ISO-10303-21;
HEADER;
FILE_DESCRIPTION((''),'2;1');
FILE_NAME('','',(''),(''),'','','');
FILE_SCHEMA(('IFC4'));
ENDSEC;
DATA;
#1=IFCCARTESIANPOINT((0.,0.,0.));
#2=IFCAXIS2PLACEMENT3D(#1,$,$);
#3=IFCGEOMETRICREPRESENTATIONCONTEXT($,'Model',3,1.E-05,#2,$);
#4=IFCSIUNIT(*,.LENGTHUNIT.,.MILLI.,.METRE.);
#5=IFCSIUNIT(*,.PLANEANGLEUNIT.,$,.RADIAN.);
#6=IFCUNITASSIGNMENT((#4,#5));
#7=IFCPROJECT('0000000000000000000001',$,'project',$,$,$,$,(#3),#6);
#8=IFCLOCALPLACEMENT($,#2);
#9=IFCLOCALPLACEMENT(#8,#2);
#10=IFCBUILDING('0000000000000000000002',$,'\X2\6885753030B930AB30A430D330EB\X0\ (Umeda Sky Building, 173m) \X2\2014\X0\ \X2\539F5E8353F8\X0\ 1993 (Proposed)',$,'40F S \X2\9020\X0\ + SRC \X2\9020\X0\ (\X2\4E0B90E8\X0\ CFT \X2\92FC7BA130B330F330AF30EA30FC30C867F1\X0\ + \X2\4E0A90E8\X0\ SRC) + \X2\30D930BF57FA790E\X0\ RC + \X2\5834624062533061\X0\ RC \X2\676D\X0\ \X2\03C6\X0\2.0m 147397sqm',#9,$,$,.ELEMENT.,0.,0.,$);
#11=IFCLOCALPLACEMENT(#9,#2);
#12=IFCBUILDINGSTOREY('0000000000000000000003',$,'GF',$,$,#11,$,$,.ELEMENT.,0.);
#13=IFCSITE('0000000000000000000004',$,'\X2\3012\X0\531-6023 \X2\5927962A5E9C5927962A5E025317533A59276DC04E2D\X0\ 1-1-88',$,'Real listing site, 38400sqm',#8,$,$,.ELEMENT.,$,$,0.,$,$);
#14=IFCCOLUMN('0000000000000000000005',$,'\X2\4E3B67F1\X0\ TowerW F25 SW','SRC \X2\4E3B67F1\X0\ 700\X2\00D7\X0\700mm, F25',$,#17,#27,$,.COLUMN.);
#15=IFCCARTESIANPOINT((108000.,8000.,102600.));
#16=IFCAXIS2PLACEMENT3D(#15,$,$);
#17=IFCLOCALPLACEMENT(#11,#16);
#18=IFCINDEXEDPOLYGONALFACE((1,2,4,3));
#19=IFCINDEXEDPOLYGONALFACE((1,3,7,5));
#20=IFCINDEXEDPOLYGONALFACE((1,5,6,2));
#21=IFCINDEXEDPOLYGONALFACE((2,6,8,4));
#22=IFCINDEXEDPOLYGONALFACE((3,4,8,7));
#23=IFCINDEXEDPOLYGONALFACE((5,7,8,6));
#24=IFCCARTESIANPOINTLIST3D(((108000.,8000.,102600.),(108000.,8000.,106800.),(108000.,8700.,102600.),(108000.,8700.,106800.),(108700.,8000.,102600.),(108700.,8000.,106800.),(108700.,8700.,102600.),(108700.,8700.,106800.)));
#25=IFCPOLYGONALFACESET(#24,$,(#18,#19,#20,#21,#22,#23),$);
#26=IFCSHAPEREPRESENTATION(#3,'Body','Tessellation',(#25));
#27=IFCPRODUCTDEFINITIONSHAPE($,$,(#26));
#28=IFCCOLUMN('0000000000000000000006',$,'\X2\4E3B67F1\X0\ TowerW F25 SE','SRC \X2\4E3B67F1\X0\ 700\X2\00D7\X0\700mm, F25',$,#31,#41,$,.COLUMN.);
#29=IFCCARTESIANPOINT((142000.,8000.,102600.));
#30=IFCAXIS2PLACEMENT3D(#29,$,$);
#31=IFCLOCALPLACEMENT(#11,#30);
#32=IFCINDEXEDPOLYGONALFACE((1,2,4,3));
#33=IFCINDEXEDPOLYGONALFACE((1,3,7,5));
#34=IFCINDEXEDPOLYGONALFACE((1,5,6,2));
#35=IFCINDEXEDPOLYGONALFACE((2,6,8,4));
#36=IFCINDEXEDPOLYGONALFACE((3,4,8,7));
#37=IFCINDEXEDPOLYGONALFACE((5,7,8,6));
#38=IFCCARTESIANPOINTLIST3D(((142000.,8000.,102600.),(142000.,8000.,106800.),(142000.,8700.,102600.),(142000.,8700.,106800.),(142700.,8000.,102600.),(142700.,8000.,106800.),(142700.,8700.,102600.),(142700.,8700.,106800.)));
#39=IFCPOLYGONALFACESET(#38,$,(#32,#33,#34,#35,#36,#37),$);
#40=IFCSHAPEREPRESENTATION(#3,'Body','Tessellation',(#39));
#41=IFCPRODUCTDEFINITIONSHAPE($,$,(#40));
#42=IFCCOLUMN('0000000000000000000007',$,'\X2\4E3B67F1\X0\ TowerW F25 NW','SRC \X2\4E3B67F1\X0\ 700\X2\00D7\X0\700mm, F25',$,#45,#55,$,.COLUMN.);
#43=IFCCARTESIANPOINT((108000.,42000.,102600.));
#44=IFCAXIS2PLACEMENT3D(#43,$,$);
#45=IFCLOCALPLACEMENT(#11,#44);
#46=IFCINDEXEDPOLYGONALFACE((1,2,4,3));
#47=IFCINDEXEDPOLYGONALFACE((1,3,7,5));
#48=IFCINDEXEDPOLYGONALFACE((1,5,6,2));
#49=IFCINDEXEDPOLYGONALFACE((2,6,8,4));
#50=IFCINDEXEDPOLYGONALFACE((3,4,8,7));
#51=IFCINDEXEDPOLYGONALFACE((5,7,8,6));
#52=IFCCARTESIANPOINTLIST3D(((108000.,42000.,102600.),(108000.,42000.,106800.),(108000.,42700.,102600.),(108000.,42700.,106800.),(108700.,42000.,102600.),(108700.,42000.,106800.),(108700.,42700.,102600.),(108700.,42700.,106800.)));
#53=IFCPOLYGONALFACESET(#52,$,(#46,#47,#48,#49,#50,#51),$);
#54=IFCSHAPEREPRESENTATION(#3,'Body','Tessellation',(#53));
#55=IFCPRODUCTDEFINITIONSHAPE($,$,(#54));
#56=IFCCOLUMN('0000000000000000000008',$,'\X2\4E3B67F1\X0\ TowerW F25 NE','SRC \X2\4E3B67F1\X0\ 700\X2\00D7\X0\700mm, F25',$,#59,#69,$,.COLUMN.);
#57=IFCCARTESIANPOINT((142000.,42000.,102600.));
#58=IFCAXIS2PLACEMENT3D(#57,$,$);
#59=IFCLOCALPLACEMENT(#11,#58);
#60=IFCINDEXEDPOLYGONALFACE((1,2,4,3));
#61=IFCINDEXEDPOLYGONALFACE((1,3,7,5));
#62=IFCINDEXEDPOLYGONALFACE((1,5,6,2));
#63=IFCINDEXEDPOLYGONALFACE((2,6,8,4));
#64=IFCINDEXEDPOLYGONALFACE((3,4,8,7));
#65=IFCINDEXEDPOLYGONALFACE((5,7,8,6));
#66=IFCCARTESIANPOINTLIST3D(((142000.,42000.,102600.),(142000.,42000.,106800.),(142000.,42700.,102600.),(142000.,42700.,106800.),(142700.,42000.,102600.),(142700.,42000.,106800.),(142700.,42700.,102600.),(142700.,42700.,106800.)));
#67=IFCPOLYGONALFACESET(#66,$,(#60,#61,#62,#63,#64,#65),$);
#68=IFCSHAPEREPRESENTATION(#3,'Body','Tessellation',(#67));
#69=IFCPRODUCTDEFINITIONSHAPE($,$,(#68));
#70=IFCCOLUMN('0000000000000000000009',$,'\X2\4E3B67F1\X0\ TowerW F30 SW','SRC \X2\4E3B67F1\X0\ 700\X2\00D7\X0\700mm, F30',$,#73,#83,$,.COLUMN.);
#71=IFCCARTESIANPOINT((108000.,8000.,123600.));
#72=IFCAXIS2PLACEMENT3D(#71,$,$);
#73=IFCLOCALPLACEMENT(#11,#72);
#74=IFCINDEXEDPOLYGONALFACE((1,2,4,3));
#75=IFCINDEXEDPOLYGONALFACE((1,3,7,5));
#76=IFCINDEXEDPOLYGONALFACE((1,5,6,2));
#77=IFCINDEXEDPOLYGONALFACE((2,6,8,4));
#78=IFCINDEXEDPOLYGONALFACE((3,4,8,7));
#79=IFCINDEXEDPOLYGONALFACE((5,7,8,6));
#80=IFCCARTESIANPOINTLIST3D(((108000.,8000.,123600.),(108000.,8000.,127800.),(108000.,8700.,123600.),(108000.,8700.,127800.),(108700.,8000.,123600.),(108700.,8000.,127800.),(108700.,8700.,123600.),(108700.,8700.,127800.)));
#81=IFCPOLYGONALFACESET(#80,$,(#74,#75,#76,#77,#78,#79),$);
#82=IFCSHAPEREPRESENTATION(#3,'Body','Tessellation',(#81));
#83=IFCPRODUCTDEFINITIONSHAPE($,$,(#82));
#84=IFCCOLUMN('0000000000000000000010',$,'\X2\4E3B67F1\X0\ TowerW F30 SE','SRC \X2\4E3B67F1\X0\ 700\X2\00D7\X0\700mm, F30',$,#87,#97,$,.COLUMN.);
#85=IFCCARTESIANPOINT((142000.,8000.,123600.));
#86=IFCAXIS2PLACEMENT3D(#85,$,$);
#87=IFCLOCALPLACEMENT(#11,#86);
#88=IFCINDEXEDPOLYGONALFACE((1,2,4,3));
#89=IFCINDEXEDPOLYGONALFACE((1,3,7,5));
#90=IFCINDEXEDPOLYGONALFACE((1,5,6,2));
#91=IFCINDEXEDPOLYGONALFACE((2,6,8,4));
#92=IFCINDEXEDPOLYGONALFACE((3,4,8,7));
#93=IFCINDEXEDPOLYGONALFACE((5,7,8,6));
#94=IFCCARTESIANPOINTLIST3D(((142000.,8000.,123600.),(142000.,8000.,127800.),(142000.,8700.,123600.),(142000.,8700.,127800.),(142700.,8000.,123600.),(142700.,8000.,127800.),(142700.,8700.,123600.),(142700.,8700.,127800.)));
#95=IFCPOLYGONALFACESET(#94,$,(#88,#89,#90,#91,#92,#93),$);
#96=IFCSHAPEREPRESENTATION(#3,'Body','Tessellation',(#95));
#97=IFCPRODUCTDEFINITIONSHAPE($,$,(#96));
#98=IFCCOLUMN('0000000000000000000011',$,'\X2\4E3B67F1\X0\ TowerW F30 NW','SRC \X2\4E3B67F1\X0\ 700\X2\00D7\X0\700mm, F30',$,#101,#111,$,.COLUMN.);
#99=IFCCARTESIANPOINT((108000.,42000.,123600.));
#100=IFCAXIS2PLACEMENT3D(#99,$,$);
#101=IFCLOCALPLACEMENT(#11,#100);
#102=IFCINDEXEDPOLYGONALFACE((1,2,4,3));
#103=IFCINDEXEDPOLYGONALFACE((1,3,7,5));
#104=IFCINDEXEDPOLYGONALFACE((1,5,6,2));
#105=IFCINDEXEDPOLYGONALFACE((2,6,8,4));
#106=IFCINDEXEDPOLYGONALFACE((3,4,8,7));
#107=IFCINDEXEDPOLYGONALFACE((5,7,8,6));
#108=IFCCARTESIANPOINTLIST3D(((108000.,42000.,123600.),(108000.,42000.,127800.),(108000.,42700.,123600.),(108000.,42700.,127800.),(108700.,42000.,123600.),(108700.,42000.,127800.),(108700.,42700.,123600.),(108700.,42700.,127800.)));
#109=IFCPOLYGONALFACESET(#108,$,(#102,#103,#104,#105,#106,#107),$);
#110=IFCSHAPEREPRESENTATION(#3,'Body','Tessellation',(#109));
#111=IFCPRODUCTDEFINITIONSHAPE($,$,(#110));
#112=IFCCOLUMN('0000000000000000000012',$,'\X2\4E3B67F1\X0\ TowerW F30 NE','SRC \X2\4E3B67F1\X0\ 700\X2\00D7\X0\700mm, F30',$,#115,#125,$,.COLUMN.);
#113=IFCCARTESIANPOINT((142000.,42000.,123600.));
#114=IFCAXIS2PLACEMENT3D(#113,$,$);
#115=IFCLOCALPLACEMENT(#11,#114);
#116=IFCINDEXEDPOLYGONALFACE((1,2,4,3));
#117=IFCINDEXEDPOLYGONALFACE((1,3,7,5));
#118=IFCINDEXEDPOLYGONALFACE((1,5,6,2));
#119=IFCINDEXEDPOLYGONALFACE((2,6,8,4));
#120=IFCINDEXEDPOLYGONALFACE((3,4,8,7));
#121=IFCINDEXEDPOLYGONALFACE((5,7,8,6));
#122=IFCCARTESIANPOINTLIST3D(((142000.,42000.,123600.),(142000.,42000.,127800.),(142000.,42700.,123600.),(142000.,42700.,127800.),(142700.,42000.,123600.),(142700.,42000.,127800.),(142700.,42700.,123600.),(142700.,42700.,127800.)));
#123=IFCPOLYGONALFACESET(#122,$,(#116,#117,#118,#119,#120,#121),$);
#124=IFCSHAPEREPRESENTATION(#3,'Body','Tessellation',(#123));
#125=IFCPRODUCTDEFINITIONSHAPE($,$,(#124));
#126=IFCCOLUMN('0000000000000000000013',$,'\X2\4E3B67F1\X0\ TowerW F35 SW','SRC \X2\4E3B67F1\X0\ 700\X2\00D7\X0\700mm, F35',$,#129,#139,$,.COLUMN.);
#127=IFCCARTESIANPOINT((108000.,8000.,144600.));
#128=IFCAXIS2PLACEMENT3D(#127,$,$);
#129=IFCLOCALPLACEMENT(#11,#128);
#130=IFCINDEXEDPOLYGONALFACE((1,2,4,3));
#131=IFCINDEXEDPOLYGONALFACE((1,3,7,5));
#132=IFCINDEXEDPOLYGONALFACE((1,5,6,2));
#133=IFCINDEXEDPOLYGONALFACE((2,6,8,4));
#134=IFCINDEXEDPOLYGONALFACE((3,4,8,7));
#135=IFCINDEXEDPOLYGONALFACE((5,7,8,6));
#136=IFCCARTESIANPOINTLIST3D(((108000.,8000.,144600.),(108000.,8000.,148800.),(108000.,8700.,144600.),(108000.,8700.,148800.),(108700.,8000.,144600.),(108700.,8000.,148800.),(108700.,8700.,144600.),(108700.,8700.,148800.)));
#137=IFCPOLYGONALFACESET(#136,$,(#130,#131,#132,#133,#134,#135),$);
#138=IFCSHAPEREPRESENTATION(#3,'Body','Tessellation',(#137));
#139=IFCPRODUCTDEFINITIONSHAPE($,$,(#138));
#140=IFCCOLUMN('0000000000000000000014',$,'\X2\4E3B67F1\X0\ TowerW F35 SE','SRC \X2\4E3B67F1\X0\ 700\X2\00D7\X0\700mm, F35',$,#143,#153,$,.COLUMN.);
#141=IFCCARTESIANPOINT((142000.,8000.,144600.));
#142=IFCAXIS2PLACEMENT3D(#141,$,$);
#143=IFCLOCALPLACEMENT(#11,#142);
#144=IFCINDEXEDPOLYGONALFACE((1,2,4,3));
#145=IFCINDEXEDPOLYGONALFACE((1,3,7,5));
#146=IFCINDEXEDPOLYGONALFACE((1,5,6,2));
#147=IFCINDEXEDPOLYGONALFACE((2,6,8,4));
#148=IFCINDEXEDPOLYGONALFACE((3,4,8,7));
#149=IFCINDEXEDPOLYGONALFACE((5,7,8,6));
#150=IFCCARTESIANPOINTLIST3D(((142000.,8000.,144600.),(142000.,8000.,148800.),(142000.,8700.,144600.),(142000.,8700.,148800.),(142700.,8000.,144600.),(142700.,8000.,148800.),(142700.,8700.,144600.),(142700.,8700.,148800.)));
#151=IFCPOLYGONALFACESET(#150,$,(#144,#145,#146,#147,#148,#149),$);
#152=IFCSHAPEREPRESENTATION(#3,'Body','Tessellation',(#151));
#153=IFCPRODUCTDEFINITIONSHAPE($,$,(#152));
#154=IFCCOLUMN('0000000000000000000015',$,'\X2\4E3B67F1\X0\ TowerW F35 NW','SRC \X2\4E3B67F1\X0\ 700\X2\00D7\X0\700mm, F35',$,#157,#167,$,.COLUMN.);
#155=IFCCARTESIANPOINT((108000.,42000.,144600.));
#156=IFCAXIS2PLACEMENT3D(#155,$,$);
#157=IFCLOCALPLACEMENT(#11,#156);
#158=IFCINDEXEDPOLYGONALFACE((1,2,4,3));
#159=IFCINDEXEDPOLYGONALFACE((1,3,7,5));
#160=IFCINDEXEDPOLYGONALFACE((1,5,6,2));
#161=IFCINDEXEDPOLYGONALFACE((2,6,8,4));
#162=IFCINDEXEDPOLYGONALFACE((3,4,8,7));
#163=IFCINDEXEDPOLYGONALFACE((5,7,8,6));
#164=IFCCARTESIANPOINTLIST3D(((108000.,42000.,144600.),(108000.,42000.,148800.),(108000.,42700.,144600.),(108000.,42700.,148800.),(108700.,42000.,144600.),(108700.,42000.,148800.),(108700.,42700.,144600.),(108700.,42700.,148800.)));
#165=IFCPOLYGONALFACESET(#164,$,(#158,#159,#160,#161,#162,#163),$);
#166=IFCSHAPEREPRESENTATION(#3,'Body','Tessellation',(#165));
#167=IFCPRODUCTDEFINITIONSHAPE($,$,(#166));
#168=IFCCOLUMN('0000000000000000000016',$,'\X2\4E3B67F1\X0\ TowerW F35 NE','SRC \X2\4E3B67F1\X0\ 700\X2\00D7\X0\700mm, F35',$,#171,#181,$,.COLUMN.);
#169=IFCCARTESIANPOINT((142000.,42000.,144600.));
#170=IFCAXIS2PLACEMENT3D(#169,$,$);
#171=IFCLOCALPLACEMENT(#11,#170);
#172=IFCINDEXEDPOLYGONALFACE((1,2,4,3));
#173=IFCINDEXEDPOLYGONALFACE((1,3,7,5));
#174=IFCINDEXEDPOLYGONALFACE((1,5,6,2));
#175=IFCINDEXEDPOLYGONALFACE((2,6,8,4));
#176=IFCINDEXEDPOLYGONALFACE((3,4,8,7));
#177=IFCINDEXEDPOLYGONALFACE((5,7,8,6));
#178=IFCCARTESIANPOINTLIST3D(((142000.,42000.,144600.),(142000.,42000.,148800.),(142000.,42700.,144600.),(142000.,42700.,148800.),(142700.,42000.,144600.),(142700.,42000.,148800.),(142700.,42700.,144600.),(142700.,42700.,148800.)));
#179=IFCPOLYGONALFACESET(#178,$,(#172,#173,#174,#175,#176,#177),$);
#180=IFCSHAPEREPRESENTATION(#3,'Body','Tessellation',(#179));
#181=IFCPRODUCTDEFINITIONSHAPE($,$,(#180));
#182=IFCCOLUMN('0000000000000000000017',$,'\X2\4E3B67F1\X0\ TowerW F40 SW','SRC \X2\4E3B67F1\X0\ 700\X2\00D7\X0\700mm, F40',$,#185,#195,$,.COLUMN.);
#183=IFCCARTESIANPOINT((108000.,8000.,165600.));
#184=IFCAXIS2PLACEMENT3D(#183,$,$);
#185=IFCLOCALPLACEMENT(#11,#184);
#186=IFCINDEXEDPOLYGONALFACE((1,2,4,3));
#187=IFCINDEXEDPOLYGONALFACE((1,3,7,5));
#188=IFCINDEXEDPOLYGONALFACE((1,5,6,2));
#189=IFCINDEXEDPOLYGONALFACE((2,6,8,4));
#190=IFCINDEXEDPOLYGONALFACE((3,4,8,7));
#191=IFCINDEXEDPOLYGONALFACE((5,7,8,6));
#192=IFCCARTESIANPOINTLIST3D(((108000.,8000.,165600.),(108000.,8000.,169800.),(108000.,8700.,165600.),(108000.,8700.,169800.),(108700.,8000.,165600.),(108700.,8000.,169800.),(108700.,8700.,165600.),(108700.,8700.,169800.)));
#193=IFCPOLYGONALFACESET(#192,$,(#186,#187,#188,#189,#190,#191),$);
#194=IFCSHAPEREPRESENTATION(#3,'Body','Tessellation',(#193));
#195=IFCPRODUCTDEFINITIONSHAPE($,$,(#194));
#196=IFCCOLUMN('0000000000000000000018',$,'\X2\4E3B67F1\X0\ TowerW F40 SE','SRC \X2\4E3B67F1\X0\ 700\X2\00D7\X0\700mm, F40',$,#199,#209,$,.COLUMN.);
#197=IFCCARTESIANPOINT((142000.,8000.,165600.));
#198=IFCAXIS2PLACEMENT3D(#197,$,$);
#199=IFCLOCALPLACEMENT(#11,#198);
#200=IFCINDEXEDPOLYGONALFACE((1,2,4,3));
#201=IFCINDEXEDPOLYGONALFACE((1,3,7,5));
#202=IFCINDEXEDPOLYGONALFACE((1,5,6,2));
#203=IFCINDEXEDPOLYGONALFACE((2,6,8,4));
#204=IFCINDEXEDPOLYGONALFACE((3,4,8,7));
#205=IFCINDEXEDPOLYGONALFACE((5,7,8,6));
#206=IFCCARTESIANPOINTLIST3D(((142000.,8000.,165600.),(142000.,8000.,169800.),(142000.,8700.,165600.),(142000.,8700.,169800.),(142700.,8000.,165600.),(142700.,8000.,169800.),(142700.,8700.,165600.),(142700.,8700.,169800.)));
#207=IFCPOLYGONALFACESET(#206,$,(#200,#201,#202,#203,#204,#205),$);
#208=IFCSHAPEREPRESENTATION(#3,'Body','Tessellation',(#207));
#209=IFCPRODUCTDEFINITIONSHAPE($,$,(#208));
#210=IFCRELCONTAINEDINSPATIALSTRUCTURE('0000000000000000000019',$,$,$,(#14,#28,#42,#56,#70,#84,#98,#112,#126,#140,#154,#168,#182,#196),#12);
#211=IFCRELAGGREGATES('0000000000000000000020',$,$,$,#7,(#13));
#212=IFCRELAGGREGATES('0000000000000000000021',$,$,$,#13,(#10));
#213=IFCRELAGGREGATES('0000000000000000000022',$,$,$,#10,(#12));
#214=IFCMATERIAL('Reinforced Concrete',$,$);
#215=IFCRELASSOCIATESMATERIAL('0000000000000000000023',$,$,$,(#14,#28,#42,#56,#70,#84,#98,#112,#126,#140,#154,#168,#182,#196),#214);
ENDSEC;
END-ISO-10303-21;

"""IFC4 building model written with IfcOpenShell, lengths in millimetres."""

from ifc_helpers import new_model, si_unit, frame, frame_2d, origin, place, context, project, spatial, rectangle, extrude, material, element, save


model = new_model("IFC4")

# Units and contexts
model_context = context("Model", 3, precision=1e-05, world=origin())
ifc_project = project(units=[si_unit("LENGTHUNIT", "METRE", prefix="MILLI"), si_unit("PLANEANGLEUNIT", "RADIAN")], contexts=[model_context])

# Site, building, storey
site_placement = place(None, origin())
site = spatial("IfcSite", under=ifc_project, at=site_placement, Name="〒531-6023 大阪府大阪市北区大淀中 1-1-88", ObjectType="Real listing site, 38400sqm", CompositionType="ELEMENT", RefElevation=0.0)
building_placement = place(site_placement, origin())
building = spatial("IfcBuilding", under=site, at=building_placement, Name="梅田スカイビル (Umeda Sky Building, 173m) — 原広司 1993 (Proposed)", ObjectType="40F S 造 + SRC 造 (下部 CFT 鋼管コンクリート柱 + 上部 SRC) + ベタ基礎 RC + 場所打ち RC 杭 φ2.0m 147397sqm", CompositionType="ELEMENT", ElevationOfRefHeight=0.0, ElevationOfTerrain=0.0)
storey_placement = place(building_placement, origin())
storey = spatial("IfcBuildingStorey", under=building, at=storey_placement, Name="GF", CompositionType="ELEMENT", Elevation=0.0)

# Columns
ifc_material_1 = material(Name="Reinforced Concrete")
column_1_placement = place(storey_placement, frame((108000.0, 8000.0, 102600.0)))
element("IfcColumn", 1, at=column_1_placement, inside=storey, material=ifc_material_1, Name="主柱 TowerW F25 SW", Description="SRC 主柱 700×700mm, F25", PredefinedType="COLUMN", context=model_context, shape_type="SweptSolid", body=[
    extrude(rectangle(XDim=700.0, YDim=700.0, at=frame_2d((350.0, 350.0))), frame((108000.0, 8000.0, 102600.0)), (0.0, 0.0, 1.0), 4200.0),
])
column_2_placement = place(storey_placement, frame((142000.0, 8000.0, 102600.0)))
element("IfcColumn", 2, at=column_2_placement, inside=storey, material=ifc_material_1, Name="主柱 TowerW F25 SE", Description="SRC 主柱 700×700mm, F25", PredefinedType="COLUMN", context=model_context, shape_type="SweptSolid", body=[
    extrude(rectangle(XDim=700.0, YDim=700.0, at=frame_2d((350.0, 350.0))), frame((142000.0, 8000.0, 102600.0)), (0.0, 0.0, 1.0), 4200.0),
])
column_3_placement = place(storey_placement, frame((108000.0, 42000.0, 102600.0)))
element("IfcColumn", 3, at=column_3_placement, inside=storey, material=ifc_material_1, Name="主柱 TowerW F25 NW", Description="SRC 主柱 700×700mm, F25", PredefinedType="COLUMN", context=model_context, shape_type="SweptSolid", body=[
    extrude(rectangle(XDim=700.0, YDim=700.0, at=frame_2d((350.0, 350.0))), frame((108000.0, 42000.0, 102600.0)), (0.0, 0.0, 1.0), 4200.0),
])
column_4_placement = place(storey_placement, frame((142000.0, 42000.0, 102600.0)))
element("IfcColumn", 4, at=column_4_placement, inside=storey, material=ifc_material_1, Name="主柱 TowerW F25 NE", Description="SRC 主柱 700×700mm, F25", PredefinedType="COLUMN", context=model_context, shape_type="SweptSolid", body=[
    extrude(rectangle(XDim=700.0, YDim=700.0, at=frame_2d((350.0, 350.0))), frame((142000.0, 42000.0, 102600.0)), (0.0, 0.0, 1.0), 4200.0),
])
column_5_placement = place(storey_placement, frame((108000.0, 8000.0, 123600.0)))
element("IfcColumn", 5, at=column_5_placement, inside=storey, material=ifc_material_1, Name="主柱 TowerW F30 SW", Description="SRC 主柱 700×700mm, F30", PredefinedType="COLUMN", context=model_context, shape_type="SweptSolid", body=[
    extrude(rectangle(XDim=700.0, YDim=700.0, at=frame_2d((350.0, 350.0))), frame((108000.0, 8000.0, 123600.0)), (0.0, 0.0, 1.0), 4200.0),
])
column_6_placement = place(storey_placement, frame((142000.0, 8000.0, 123600.0)))
element("IfcColumn", 6, at=column_6_placement, inside=storey, material=ifc_material_1, Name="主柱 TowerW F30 SE", Description="SRC 主柱 700×700mm, F30", PredefinedType="COLUMN", context=model_context, shape_type="SweptSolid", body=[
    extrude(rectangle(XDim=700.0, YDim=700.0, at=frame_2d((350.0, 350.0))), frame((142000.0, 8000.0, 123600.0)), (0.0, 0.0, 1.0), 4200.0),
])
column_7_placement = place(storey_placement, frame((108000.0, 42000.0, 123600.0)))
element("IfcColumn", 7, at=column_7_placement, inside=storey, material=ifc_material_1, Name="主柱 TowerW F30 NW", Description="SRC 主柱 700×700mm, F30", PredefinedType="COLUMN", context=model_context, shape_type="SweptSolid", body=[
    extrude(rectangle(XDim=700.0, YDim=700.0, at=frame_2d((350.0, 350.0))), frame((108000.0, 42000.0, 123600.0)), (0.0, 0.0, 1.0), 4200.0),
])
column_8_placement = place(storey_placement, frame((142000.0, 42000.0, 123600.0)))
element("IfcColumn", 8, at=column_8_placement, inside=storey, material=ifc_material_1, Name="主柱 TowerW F30 NE", Description="SRC 主柱 700×700mm, F30", PredefinedType="COLUMN", context=model_context, shape_type="SweptSolid", body=[
    extrude(rectangle(XDim=700.0, YDim=700.0, at=frame_2d((350.0, 350.0))), frame((142000.0, 42000.0, 123600.0)), (0.0, 0.0, 1.0), 4200.0),
])
column_9_placement = place(storey_placement, frame((108000.0, 8000.0, 144600.0)))
element("IfcColumn", 9, at=column_9_placement, inside=storey, material=ifc_material_1, Name="主柱 TowerW F35 SW", Description="SRC 主柱 700×700mm, F35", PredefinedType="COLUMN", context=model_context, shape_type="SweptSolid", body=[
    extrude(rectangle(XDim=700.0, YDim=700.0, at=frame_2d((350.0, 350.0))), frame((108000.0, 8000.0, 144600.0)), (0.0, 0.0, 1.0), 4200.0),
])
column_10_placement = place(storey_placement, frame((142000.0, 8000.0, 144600.0)))
element("IfcColumn", 10, at=column_10_placement, inside=storey, material=ifc_material_1, Name="主柱 TowerW F35 SE", Description="SRC 主柱 700×700mm, F35", PredefinedType="COLUMN", context=model_context, shape_type="SweptSolid", body=[
    extrude(rectangle(XDim=700.0, YDim=700.0, at=frame_2d((350.0, 350.0))), frame((142000.0, 8000.0, 144600.0)), (0.0, 0.0, 1.0), 4200.0),
])
column_11_placement = place(storey_placement, frame((108000.0, 42000.0, 144600.0)))
element("IfcColumn", 11, at=column_11_placement, inside=storey, material=ifc_material_1, Name="主柱 TowerW F35 NW", Description="SRC 主柱 700×700mm, F35", PredefinedType="COLUMN", context=model_context, shape_type="SweptSolid", body=[
    extrude(rectangle(XDim=700.0, YDim=700.0, at=frame_2d((350.0, 350.0))), frame((108000.0, 42000.0, 144600.0)), (0.0, 0.0, 1.0), 4200.0),
])
column_12_placement = place(storey_placement, frame((142000.0, 42000.0, 144600.0)))
element("IfcColumn", 12, at=column_12_placement, inside=storey, material=ifc_material_1, Name="主柱 TowerW F35 NE", Description="SRC 主柱 700×700mm, F35", PredefinedType="COLUMN", context=model_context, shape_type="SweptSolid", body=[
    extrude(rectangle(XDim=700.0, YDim=700.0, at=frame_2d((350.0, 350.0))), frame((142000.0, 42000.0, 144600.0)), (0.0, 0.0, 1.0), 4200.0),
])
column_13_placement = place(storey_placement, frame((108000.0, 8000.0, 165600.0)))
element("IfcColumn", 13, at=column_13_placement, inside=storey, material=ifc_material_1, Name="主柱 TowerW F40 SW", Description="SRC 主柱 700×700mm, F40", PredefinedType="COLUMN", context=model_context, shape_type="SweptSolid", body=[
    extrude(rectangle(XDim=700.0, YDim=700.0, at=frame_2d((350.0, 350.0))), frame((108000.0, 8000.0, 165600.0)), (0.0, 0.0, 1.0), 4200.0),
])
column_14_placement = place(storey_placement, frame((142000.0, 8000.0, 165600.0)))
element("IfcColumn", 14, at=column_14_placement, inside=storey, material=ifc_material_1, Name="主柱 TowerW F40 SE", Description="SRC 主柱 700×700mm, F40", PredefinedType="COLUMN", context=model_context, shape_type="SweptSolid", body=[
    extrude(rectangle(XDim=700.0, YDim=700.0, at=frame_2d((350.0, 350.0))), frame((142000.0, 8000.0, 165600.0)), (0.0, 0.0, 1.0), 4200.0),
])

save(model, "model.ifc")
